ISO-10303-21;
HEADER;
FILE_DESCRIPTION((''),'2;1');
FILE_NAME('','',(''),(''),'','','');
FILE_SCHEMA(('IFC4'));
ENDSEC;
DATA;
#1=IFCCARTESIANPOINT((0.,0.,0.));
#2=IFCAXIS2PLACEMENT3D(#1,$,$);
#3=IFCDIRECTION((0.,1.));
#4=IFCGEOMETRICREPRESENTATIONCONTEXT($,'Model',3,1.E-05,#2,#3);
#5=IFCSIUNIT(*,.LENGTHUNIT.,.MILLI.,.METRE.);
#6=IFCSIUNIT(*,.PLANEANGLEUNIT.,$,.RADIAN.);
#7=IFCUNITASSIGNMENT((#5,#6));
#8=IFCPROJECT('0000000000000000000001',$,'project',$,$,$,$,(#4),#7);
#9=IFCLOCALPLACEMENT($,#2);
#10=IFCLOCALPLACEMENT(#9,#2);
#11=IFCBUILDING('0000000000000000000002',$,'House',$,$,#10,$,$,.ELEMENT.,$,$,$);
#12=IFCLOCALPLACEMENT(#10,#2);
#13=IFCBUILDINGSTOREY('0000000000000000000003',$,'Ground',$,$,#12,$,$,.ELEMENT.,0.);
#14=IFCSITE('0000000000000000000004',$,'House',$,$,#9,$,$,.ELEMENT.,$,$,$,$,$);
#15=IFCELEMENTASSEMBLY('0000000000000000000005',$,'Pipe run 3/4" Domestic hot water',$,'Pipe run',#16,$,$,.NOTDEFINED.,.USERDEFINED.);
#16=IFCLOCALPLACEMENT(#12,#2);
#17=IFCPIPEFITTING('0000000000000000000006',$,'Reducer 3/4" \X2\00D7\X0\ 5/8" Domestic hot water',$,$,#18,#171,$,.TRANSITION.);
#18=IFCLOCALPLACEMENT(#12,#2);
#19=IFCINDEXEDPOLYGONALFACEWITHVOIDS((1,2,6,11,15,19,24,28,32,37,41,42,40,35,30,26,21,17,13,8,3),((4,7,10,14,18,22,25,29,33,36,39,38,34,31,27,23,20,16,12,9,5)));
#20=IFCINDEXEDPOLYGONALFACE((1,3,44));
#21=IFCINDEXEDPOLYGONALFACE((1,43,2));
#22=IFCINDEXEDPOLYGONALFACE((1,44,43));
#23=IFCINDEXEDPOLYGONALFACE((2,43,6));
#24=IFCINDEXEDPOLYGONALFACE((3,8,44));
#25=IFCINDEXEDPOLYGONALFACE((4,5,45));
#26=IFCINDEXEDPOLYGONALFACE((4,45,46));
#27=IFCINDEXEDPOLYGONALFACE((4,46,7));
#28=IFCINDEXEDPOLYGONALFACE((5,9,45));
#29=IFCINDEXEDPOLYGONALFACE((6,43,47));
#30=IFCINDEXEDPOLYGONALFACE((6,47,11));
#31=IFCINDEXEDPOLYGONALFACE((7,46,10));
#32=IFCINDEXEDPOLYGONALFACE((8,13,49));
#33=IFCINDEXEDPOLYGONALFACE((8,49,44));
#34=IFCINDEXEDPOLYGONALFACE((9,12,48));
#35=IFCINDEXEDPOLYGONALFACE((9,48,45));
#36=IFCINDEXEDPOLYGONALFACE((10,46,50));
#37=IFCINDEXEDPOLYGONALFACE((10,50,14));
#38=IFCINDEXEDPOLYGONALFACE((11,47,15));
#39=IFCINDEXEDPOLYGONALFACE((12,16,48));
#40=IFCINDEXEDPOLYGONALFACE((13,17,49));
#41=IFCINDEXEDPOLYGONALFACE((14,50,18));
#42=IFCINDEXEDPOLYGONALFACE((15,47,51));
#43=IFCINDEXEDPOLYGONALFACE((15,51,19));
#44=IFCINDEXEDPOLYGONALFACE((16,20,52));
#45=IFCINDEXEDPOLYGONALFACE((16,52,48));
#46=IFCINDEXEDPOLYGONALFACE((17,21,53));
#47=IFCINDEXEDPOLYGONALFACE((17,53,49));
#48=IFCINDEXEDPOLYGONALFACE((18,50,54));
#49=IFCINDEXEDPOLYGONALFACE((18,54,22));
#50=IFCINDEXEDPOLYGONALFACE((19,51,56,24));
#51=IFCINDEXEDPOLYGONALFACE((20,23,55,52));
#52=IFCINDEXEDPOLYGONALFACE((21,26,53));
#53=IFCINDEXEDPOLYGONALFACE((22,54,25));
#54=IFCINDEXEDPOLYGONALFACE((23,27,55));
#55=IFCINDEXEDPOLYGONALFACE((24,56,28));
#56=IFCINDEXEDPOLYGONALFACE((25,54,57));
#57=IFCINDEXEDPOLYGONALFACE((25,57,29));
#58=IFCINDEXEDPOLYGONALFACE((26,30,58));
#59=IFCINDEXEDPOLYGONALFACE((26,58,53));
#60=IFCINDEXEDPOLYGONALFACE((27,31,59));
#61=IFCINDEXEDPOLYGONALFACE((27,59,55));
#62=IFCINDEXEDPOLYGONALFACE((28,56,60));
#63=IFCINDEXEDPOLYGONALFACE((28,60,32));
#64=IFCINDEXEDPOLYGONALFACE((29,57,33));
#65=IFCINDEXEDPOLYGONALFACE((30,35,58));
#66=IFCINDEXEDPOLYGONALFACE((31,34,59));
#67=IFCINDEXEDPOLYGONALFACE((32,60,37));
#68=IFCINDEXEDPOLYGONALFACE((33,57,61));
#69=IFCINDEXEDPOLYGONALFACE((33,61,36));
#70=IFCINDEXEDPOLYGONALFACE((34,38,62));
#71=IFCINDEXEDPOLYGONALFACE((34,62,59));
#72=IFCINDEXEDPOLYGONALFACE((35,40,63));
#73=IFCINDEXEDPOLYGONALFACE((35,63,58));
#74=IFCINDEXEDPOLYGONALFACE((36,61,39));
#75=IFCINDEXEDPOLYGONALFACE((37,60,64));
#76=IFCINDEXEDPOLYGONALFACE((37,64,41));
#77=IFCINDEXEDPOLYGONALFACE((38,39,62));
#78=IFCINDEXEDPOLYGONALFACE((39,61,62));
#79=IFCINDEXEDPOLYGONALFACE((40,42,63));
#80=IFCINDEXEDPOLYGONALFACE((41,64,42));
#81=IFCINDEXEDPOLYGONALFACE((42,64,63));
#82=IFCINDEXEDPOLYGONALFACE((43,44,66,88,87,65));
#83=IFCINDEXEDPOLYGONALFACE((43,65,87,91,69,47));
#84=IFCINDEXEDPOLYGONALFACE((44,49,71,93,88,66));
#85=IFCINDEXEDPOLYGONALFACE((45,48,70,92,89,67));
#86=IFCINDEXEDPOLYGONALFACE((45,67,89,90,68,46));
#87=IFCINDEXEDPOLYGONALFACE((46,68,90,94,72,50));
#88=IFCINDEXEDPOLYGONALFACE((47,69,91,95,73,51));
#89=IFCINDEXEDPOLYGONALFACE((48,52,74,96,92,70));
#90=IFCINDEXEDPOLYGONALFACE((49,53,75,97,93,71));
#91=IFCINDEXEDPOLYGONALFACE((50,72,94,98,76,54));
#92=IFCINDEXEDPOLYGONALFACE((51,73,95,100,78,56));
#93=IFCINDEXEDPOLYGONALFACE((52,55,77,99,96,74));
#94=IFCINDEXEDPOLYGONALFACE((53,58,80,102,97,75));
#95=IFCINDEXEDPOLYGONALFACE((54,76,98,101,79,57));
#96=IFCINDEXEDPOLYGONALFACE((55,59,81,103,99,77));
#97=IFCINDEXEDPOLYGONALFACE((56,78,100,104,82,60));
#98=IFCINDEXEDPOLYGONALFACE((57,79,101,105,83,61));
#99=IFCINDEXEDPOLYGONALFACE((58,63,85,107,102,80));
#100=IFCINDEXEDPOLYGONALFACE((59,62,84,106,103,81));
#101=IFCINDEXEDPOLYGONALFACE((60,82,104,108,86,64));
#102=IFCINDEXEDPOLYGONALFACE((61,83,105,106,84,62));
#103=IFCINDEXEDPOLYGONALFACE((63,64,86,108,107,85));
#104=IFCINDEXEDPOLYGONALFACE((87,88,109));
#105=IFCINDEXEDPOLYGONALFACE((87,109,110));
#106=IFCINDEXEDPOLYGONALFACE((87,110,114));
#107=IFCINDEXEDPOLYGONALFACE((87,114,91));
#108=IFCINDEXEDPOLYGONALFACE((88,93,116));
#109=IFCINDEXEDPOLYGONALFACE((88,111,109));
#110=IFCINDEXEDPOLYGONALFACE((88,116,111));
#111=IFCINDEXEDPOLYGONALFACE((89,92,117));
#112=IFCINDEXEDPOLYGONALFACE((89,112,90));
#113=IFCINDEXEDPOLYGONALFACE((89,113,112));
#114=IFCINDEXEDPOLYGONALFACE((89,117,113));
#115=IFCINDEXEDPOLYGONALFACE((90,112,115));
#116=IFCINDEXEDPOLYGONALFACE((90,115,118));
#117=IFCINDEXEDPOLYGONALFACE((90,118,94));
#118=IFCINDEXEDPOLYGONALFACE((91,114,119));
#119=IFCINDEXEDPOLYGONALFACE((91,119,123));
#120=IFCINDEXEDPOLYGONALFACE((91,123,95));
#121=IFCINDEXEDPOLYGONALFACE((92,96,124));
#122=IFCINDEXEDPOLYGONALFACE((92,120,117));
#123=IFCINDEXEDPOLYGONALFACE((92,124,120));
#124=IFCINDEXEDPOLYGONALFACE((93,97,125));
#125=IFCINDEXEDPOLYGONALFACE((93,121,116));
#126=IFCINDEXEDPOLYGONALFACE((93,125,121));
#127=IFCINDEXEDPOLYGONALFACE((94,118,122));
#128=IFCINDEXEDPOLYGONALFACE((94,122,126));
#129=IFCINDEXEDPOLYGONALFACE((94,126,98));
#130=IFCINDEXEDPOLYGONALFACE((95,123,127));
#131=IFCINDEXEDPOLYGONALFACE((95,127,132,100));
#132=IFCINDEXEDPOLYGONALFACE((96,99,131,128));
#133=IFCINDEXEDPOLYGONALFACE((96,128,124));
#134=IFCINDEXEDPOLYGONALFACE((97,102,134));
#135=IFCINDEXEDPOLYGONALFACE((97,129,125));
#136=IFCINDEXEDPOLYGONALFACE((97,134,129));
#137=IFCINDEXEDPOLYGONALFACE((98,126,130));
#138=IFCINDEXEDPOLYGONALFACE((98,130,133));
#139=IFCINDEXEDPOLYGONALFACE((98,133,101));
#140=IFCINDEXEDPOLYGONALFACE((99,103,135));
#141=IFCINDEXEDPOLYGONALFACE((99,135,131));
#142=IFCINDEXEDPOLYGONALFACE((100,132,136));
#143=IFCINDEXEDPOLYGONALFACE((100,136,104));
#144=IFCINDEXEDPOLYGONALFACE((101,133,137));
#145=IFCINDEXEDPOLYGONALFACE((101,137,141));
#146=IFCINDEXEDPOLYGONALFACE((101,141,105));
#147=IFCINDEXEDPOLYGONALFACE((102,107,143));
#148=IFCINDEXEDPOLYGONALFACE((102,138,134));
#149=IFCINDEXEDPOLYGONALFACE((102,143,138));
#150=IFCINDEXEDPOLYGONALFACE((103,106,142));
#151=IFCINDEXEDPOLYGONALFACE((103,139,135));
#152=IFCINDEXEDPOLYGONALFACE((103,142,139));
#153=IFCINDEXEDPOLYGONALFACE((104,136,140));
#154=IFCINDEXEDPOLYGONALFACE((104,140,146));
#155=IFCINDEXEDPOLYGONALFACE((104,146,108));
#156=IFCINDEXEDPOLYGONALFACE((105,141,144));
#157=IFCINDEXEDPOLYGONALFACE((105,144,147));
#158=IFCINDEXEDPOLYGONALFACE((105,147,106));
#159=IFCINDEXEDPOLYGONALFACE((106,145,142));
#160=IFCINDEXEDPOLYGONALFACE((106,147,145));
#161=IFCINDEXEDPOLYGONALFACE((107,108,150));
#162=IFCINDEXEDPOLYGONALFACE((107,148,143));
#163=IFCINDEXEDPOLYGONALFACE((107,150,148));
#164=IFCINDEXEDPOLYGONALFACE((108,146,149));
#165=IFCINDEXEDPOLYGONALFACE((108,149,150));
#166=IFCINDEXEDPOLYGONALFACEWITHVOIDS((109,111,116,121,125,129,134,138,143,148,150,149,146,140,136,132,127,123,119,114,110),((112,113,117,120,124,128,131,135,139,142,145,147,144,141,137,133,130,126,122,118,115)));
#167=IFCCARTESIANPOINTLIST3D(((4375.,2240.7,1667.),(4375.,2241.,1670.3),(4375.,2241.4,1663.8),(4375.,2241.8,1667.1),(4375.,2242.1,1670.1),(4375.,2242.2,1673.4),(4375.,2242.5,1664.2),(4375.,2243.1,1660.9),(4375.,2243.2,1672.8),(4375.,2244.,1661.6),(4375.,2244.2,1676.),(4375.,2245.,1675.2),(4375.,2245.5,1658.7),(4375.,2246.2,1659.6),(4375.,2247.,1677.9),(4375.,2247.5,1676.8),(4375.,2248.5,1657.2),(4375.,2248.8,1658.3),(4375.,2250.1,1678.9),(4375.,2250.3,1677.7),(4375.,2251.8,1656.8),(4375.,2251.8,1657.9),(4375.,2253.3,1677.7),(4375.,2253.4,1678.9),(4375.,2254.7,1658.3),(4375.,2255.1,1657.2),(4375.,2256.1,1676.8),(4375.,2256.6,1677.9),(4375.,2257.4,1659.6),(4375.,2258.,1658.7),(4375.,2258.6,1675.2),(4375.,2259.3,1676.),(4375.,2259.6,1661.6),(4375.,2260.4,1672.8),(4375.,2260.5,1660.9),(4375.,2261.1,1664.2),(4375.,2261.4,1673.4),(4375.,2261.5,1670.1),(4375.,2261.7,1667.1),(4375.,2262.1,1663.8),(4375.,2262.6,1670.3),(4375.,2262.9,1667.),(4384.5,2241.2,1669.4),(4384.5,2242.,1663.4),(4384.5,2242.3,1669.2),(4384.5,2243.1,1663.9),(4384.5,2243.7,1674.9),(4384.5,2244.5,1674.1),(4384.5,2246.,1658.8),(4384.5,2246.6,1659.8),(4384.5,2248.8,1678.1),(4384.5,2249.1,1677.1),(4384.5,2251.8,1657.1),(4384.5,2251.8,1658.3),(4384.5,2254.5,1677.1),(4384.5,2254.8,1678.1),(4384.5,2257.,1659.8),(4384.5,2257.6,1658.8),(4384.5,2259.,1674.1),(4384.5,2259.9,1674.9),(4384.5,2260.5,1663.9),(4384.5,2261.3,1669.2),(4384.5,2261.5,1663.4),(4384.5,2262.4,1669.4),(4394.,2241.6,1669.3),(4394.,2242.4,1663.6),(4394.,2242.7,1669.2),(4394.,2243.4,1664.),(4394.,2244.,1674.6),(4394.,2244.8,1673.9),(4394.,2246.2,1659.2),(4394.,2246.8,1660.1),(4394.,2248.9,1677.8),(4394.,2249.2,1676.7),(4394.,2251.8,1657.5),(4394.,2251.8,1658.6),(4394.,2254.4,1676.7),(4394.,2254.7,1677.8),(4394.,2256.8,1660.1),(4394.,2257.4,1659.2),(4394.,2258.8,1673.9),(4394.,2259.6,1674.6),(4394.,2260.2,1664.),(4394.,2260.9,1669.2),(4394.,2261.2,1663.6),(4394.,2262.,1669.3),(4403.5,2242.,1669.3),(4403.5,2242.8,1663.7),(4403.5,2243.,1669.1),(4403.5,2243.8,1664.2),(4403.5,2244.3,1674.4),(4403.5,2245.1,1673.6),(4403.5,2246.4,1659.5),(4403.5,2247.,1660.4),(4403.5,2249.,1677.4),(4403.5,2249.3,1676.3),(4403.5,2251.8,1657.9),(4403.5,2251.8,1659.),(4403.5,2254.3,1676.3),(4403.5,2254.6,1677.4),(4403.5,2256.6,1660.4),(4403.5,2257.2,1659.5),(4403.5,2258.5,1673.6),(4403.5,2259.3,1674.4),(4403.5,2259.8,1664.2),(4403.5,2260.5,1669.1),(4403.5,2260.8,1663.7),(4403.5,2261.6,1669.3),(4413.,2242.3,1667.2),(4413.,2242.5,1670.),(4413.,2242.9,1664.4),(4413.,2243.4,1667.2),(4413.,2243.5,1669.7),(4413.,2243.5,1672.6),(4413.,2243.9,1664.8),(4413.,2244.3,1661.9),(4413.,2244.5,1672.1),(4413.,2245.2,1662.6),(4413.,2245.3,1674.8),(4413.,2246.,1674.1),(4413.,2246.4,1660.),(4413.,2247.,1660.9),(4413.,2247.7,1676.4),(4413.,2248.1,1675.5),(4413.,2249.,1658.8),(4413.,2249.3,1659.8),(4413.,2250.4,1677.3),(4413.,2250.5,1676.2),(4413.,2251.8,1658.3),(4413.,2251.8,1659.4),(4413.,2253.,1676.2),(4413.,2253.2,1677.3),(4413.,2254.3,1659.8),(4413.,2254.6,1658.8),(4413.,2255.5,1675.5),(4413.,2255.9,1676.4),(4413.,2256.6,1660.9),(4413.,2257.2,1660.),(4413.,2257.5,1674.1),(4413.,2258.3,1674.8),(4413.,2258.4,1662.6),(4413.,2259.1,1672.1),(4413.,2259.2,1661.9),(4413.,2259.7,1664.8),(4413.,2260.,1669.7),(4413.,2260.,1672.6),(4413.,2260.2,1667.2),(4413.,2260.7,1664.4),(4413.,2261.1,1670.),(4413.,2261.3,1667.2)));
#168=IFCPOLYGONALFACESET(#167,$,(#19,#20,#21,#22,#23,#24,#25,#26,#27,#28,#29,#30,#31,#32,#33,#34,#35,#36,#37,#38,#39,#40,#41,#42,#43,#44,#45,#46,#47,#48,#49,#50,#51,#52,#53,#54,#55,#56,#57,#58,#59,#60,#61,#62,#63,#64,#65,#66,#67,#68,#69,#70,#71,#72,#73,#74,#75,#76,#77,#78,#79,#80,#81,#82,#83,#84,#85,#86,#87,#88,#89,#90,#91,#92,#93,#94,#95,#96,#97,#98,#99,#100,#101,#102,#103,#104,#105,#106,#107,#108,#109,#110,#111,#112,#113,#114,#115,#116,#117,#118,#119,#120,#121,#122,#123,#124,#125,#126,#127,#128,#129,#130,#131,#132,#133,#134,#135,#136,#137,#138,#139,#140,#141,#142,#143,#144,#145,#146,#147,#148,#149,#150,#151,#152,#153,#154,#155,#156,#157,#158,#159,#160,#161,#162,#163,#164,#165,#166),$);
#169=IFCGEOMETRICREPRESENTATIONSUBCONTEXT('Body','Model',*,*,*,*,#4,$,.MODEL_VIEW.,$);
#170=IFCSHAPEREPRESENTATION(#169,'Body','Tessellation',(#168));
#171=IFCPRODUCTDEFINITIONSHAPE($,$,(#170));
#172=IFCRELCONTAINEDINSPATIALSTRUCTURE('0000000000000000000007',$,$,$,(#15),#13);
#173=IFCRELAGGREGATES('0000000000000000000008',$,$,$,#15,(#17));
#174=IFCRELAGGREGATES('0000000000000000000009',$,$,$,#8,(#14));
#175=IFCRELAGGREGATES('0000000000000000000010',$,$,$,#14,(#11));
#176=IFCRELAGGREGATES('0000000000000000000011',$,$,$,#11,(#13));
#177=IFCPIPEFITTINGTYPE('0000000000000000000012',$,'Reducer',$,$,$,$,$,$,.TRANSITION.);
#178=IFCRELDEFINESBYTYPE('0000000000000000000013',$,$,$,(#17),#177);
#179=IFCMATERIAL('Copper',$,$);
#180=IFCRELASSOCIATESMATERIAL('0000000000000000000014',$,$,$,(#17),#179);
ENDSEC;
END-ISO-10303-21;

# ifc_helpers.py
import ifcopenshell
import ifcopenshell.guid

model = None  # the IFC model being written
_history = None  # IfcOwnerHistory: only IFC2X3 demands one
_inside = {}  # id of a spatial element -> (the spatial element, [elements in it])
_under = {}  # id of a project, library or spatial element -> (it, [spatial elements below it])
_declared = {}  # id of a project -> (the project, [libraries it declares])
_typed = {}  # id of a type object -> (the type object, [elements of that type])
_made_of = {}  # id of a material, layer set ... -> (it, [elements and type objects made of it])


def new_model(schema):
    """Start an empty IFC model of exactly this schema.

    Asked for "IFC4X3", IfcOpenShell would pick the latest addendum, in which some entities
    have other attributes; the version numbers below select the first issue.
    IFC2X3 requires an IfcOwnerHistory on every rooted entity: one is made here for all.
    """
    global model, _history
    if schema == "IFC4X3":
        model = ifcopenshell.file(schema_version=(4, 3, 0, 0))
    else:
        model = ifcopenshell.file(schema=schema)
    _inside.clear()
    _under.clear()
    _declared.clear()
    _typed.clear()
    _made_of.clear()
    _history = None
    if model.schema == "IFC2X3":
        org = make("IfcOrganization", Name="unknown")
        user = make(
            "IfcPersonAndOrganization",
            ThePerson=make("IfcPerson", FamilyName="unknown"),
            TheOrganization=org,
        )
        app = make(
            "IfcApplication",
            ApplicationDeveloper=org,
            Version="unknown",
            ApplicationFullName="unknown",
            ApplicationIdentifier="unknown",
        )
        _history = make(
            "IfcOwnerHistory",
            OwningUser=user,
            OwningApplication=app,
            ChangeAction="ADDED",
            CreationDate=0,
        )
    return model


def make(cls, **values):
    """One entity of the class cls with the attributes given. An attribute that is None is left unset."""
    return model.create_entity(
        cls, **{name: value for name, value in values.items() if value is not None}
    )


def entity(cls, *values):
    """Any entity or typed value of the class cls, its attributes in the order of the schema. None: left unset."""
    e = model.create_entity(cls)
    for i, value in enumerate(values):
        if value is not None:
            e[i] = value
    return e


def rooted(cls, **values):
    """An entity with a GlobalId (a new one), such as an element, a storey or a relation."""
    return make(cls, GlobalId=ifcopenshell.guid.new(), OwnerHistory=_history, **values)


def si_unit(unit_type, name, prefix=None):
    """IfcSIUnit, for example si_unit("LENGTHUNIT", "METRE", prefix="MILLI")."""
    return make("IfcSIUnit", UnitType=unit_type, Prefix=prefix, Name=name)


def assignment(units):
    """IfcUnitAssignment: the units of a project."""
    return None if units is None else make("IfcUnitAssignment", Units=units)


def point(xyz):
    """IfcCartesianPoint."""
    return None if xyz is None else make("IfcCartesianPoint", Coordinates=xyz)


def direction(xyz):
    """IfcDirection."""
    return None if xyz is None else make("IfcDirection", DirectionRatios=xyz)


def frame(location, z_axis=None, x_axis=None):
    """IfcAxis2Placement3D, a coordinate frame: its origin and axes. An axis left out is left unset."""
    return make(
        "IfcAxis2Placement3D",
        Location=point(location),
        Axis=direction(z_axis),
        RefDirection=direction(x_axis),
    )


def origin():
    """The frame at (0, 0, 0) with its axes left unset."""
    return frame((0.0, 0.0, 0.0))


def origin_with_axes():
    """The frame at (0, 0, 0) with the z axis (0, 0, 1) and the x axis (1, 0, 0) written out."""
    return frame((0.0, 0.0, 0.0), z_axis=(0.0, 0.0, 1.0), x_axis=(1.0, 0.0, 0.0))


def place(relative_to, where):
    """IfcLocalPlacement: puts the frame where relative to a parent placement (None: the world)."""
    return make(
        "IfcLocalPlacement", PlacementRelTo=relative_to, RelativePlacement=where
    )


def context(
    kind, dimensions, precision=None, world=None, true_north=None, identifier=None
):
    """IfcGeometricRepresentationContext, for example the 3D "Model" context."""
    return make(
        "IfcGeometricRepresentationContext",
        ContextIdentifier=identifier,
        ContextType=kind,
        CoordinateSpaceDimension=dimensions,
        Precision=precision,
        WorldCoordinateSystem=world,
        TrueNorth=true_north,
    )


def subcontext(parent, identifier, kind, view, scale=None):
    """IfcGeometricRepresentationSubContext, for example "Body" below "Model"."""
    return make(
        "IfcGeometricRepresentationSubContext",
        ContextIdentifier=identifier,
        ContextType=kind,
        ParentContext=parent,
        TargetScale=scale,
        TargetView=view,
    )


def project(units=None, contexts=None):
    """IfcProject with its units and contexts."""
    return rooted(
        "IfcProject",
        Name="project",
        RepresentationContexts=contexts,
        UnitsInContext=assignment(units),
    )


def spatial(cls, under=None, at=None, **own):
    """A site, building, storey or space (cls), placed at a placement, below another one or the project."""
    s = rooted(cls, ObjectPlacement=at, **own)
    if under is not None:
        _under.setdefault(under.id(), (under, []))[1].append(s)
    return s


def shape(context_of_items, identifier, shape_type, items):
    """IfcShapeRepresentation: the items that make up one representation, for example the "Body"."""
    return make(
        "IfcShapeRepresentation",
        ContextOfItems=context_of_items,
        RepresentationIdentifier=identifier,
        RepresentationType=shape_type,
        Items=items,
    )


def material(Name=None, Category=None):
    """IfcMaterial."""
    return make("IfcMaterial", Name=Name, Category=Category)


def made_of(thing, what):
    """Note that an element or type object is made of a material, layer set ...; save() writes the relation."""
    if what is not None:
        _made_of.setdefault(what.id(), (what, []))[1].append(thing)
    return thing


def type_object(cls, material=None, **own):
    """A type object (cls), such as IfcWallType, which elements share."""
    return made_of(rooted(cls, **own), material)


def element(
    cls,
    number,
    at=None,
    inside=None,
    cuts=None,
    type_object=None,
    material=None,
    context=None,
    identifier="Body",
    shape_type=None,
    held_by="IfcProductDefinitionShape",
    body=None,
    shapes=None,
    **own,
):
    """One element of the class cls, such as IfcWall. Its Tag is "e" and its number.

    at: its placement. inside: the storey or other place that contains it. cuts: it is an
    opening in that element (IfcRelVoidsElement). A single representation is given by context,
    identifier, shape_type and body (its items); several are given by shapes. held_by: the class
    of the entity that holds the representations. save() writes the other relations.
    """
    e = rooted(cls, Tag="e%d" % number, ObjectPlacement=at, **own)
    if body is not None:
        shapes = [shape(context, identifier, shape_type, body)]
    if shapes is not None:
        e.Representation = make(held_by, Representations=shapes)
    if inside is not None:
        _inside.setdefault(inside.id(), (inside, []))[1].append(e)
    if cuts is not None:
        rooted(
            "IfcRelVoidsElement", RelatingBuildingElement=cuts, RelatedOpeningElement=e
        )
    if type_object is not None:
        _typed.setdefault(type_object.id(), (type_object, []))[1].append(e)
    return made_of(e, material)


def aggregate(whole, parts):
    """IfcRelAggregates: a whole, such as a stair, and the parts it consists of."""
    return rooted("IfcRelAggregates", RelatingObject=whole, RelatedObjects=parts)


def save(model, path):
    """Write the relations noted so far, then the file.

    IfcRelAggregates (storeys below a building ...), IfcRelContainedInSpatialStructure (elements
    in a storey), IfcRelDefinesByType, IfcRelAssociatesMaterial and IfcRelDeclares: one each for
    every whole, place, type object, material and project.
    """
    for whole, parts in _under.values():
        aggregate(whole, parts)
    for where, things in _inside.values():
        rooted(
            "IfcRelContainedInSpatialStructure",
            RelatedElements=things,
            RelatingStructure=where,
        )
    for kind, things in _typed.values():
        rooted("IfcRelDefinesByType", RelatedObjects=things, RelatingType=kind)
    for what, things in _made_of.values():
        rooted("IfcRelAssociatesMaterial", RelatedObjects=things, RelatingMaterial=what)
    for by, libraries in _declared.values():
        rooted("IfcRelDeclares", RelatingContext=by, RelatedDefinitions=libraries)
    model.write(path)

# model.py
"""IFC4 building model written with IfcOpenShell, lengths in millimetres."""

from ifc_helpers import new_model, entity, si_unit, direction, origin, origin_with_axes, place, context, subcontext, project, spatial, material, type_object, element, aggregate, save


model = new_model("IFC4")

# Units and contexts
model_context = context("Model", 3, precision=1e-05, world=origin(), true_north=direction((0.0, 1.0)))
body_context = subcontext(model_context, "Body", "Model", "MODEL_VIEW")
ifc_project = project(units=[si_unit("LENGTHUNIT", "METRE", prefix="MILLI"), si_unit("PLANEANGLEUNIT", "RADIAN")], contexts=[model_context])

# Site, building, storey
site_placement = place(None, origin())
site = spatial("IfcSite", under=ifc_project, at=site_placement, Name="House", CompositionType="ELEMENT")
building_placement = place(site_placement, origin())
building = spatial("IfcBuilding", under=site, at=building_placement, Name="House", CompositionType="ELEMENT")
storey_placement = place(building_placement, origin())
storey = spatial("IfcBuildingStorey", under=building, at=storey_placement, Name="Ground", CompositionType="ELEMENT", Elevation=0.0)

# Shared definitions
ifc_material = material(Name="Copper")

# Element assembly, pipe fitting
assembly_1_placement = place(storey_placement, origin_with_axes())
assembly_1 = element("IfcElementAssembly", 1, at=assembly_1_placement, inside=storey, Name="Pipe run 3/4\" Domestic hot water", ObjectType="Pipe run", AssemblyPlace="NOTDEFINED", PredefinedType="USERDEFINED")
pipe_fitting_type_1 = type_object("IfcPipeFittingType", Name="Reducer", PredefinedType="TRANSITION")
pipe_fitting_1_placement = place(storey_placement, origin_with_axes())
cartesian_point_1 = entity("IfcCartesianPoint", [0.0, 10.0])
pipe_fitting_1 = element("IfcPipeFitting", 2, at=pipe_fitting_1_placement, type_object=pipe_fitting_type_1, material=ifc_material, Name="Reducer 3/4\" × 5/8\" Domestic hot water", PredefinedType="TRANSITION", context=body_context, shape_type="SweptSolid", body=[
    entity("IfcRevolvedAreaSolid", entity("IfcArbitraryClosedProfileDef", "AREA", None, entity("IfcPolyline", [cartesian_point_1, entity("IfcCartesianPoint", [0.0, 11.1]), entity("IfcCartesianPoint", [38.0, 9.5]), entity("IfcCartesianPoint", [38.0, 8.5]), cartesian_point_1])), entity("IfcAxis2Placement3D", entity("IfcCartesianPoint", [4375.0, 2251.8, 1667.9]), entity("IfcDirection", [0.0, 1.0, 0.0]), entity("IfcDirection", [1.0, 0.0, 0.0])), entity("IfcAxis1Placement", entity("IfcCartesianPoint", [0.0, 0.0, 0.0]), entity("IfcDirection", [1.0, 0.0, 0.0])), 6.283185),
])
aggregate(assembly_1, [pipe_fitting_1])

save(model, "model.ifc")
